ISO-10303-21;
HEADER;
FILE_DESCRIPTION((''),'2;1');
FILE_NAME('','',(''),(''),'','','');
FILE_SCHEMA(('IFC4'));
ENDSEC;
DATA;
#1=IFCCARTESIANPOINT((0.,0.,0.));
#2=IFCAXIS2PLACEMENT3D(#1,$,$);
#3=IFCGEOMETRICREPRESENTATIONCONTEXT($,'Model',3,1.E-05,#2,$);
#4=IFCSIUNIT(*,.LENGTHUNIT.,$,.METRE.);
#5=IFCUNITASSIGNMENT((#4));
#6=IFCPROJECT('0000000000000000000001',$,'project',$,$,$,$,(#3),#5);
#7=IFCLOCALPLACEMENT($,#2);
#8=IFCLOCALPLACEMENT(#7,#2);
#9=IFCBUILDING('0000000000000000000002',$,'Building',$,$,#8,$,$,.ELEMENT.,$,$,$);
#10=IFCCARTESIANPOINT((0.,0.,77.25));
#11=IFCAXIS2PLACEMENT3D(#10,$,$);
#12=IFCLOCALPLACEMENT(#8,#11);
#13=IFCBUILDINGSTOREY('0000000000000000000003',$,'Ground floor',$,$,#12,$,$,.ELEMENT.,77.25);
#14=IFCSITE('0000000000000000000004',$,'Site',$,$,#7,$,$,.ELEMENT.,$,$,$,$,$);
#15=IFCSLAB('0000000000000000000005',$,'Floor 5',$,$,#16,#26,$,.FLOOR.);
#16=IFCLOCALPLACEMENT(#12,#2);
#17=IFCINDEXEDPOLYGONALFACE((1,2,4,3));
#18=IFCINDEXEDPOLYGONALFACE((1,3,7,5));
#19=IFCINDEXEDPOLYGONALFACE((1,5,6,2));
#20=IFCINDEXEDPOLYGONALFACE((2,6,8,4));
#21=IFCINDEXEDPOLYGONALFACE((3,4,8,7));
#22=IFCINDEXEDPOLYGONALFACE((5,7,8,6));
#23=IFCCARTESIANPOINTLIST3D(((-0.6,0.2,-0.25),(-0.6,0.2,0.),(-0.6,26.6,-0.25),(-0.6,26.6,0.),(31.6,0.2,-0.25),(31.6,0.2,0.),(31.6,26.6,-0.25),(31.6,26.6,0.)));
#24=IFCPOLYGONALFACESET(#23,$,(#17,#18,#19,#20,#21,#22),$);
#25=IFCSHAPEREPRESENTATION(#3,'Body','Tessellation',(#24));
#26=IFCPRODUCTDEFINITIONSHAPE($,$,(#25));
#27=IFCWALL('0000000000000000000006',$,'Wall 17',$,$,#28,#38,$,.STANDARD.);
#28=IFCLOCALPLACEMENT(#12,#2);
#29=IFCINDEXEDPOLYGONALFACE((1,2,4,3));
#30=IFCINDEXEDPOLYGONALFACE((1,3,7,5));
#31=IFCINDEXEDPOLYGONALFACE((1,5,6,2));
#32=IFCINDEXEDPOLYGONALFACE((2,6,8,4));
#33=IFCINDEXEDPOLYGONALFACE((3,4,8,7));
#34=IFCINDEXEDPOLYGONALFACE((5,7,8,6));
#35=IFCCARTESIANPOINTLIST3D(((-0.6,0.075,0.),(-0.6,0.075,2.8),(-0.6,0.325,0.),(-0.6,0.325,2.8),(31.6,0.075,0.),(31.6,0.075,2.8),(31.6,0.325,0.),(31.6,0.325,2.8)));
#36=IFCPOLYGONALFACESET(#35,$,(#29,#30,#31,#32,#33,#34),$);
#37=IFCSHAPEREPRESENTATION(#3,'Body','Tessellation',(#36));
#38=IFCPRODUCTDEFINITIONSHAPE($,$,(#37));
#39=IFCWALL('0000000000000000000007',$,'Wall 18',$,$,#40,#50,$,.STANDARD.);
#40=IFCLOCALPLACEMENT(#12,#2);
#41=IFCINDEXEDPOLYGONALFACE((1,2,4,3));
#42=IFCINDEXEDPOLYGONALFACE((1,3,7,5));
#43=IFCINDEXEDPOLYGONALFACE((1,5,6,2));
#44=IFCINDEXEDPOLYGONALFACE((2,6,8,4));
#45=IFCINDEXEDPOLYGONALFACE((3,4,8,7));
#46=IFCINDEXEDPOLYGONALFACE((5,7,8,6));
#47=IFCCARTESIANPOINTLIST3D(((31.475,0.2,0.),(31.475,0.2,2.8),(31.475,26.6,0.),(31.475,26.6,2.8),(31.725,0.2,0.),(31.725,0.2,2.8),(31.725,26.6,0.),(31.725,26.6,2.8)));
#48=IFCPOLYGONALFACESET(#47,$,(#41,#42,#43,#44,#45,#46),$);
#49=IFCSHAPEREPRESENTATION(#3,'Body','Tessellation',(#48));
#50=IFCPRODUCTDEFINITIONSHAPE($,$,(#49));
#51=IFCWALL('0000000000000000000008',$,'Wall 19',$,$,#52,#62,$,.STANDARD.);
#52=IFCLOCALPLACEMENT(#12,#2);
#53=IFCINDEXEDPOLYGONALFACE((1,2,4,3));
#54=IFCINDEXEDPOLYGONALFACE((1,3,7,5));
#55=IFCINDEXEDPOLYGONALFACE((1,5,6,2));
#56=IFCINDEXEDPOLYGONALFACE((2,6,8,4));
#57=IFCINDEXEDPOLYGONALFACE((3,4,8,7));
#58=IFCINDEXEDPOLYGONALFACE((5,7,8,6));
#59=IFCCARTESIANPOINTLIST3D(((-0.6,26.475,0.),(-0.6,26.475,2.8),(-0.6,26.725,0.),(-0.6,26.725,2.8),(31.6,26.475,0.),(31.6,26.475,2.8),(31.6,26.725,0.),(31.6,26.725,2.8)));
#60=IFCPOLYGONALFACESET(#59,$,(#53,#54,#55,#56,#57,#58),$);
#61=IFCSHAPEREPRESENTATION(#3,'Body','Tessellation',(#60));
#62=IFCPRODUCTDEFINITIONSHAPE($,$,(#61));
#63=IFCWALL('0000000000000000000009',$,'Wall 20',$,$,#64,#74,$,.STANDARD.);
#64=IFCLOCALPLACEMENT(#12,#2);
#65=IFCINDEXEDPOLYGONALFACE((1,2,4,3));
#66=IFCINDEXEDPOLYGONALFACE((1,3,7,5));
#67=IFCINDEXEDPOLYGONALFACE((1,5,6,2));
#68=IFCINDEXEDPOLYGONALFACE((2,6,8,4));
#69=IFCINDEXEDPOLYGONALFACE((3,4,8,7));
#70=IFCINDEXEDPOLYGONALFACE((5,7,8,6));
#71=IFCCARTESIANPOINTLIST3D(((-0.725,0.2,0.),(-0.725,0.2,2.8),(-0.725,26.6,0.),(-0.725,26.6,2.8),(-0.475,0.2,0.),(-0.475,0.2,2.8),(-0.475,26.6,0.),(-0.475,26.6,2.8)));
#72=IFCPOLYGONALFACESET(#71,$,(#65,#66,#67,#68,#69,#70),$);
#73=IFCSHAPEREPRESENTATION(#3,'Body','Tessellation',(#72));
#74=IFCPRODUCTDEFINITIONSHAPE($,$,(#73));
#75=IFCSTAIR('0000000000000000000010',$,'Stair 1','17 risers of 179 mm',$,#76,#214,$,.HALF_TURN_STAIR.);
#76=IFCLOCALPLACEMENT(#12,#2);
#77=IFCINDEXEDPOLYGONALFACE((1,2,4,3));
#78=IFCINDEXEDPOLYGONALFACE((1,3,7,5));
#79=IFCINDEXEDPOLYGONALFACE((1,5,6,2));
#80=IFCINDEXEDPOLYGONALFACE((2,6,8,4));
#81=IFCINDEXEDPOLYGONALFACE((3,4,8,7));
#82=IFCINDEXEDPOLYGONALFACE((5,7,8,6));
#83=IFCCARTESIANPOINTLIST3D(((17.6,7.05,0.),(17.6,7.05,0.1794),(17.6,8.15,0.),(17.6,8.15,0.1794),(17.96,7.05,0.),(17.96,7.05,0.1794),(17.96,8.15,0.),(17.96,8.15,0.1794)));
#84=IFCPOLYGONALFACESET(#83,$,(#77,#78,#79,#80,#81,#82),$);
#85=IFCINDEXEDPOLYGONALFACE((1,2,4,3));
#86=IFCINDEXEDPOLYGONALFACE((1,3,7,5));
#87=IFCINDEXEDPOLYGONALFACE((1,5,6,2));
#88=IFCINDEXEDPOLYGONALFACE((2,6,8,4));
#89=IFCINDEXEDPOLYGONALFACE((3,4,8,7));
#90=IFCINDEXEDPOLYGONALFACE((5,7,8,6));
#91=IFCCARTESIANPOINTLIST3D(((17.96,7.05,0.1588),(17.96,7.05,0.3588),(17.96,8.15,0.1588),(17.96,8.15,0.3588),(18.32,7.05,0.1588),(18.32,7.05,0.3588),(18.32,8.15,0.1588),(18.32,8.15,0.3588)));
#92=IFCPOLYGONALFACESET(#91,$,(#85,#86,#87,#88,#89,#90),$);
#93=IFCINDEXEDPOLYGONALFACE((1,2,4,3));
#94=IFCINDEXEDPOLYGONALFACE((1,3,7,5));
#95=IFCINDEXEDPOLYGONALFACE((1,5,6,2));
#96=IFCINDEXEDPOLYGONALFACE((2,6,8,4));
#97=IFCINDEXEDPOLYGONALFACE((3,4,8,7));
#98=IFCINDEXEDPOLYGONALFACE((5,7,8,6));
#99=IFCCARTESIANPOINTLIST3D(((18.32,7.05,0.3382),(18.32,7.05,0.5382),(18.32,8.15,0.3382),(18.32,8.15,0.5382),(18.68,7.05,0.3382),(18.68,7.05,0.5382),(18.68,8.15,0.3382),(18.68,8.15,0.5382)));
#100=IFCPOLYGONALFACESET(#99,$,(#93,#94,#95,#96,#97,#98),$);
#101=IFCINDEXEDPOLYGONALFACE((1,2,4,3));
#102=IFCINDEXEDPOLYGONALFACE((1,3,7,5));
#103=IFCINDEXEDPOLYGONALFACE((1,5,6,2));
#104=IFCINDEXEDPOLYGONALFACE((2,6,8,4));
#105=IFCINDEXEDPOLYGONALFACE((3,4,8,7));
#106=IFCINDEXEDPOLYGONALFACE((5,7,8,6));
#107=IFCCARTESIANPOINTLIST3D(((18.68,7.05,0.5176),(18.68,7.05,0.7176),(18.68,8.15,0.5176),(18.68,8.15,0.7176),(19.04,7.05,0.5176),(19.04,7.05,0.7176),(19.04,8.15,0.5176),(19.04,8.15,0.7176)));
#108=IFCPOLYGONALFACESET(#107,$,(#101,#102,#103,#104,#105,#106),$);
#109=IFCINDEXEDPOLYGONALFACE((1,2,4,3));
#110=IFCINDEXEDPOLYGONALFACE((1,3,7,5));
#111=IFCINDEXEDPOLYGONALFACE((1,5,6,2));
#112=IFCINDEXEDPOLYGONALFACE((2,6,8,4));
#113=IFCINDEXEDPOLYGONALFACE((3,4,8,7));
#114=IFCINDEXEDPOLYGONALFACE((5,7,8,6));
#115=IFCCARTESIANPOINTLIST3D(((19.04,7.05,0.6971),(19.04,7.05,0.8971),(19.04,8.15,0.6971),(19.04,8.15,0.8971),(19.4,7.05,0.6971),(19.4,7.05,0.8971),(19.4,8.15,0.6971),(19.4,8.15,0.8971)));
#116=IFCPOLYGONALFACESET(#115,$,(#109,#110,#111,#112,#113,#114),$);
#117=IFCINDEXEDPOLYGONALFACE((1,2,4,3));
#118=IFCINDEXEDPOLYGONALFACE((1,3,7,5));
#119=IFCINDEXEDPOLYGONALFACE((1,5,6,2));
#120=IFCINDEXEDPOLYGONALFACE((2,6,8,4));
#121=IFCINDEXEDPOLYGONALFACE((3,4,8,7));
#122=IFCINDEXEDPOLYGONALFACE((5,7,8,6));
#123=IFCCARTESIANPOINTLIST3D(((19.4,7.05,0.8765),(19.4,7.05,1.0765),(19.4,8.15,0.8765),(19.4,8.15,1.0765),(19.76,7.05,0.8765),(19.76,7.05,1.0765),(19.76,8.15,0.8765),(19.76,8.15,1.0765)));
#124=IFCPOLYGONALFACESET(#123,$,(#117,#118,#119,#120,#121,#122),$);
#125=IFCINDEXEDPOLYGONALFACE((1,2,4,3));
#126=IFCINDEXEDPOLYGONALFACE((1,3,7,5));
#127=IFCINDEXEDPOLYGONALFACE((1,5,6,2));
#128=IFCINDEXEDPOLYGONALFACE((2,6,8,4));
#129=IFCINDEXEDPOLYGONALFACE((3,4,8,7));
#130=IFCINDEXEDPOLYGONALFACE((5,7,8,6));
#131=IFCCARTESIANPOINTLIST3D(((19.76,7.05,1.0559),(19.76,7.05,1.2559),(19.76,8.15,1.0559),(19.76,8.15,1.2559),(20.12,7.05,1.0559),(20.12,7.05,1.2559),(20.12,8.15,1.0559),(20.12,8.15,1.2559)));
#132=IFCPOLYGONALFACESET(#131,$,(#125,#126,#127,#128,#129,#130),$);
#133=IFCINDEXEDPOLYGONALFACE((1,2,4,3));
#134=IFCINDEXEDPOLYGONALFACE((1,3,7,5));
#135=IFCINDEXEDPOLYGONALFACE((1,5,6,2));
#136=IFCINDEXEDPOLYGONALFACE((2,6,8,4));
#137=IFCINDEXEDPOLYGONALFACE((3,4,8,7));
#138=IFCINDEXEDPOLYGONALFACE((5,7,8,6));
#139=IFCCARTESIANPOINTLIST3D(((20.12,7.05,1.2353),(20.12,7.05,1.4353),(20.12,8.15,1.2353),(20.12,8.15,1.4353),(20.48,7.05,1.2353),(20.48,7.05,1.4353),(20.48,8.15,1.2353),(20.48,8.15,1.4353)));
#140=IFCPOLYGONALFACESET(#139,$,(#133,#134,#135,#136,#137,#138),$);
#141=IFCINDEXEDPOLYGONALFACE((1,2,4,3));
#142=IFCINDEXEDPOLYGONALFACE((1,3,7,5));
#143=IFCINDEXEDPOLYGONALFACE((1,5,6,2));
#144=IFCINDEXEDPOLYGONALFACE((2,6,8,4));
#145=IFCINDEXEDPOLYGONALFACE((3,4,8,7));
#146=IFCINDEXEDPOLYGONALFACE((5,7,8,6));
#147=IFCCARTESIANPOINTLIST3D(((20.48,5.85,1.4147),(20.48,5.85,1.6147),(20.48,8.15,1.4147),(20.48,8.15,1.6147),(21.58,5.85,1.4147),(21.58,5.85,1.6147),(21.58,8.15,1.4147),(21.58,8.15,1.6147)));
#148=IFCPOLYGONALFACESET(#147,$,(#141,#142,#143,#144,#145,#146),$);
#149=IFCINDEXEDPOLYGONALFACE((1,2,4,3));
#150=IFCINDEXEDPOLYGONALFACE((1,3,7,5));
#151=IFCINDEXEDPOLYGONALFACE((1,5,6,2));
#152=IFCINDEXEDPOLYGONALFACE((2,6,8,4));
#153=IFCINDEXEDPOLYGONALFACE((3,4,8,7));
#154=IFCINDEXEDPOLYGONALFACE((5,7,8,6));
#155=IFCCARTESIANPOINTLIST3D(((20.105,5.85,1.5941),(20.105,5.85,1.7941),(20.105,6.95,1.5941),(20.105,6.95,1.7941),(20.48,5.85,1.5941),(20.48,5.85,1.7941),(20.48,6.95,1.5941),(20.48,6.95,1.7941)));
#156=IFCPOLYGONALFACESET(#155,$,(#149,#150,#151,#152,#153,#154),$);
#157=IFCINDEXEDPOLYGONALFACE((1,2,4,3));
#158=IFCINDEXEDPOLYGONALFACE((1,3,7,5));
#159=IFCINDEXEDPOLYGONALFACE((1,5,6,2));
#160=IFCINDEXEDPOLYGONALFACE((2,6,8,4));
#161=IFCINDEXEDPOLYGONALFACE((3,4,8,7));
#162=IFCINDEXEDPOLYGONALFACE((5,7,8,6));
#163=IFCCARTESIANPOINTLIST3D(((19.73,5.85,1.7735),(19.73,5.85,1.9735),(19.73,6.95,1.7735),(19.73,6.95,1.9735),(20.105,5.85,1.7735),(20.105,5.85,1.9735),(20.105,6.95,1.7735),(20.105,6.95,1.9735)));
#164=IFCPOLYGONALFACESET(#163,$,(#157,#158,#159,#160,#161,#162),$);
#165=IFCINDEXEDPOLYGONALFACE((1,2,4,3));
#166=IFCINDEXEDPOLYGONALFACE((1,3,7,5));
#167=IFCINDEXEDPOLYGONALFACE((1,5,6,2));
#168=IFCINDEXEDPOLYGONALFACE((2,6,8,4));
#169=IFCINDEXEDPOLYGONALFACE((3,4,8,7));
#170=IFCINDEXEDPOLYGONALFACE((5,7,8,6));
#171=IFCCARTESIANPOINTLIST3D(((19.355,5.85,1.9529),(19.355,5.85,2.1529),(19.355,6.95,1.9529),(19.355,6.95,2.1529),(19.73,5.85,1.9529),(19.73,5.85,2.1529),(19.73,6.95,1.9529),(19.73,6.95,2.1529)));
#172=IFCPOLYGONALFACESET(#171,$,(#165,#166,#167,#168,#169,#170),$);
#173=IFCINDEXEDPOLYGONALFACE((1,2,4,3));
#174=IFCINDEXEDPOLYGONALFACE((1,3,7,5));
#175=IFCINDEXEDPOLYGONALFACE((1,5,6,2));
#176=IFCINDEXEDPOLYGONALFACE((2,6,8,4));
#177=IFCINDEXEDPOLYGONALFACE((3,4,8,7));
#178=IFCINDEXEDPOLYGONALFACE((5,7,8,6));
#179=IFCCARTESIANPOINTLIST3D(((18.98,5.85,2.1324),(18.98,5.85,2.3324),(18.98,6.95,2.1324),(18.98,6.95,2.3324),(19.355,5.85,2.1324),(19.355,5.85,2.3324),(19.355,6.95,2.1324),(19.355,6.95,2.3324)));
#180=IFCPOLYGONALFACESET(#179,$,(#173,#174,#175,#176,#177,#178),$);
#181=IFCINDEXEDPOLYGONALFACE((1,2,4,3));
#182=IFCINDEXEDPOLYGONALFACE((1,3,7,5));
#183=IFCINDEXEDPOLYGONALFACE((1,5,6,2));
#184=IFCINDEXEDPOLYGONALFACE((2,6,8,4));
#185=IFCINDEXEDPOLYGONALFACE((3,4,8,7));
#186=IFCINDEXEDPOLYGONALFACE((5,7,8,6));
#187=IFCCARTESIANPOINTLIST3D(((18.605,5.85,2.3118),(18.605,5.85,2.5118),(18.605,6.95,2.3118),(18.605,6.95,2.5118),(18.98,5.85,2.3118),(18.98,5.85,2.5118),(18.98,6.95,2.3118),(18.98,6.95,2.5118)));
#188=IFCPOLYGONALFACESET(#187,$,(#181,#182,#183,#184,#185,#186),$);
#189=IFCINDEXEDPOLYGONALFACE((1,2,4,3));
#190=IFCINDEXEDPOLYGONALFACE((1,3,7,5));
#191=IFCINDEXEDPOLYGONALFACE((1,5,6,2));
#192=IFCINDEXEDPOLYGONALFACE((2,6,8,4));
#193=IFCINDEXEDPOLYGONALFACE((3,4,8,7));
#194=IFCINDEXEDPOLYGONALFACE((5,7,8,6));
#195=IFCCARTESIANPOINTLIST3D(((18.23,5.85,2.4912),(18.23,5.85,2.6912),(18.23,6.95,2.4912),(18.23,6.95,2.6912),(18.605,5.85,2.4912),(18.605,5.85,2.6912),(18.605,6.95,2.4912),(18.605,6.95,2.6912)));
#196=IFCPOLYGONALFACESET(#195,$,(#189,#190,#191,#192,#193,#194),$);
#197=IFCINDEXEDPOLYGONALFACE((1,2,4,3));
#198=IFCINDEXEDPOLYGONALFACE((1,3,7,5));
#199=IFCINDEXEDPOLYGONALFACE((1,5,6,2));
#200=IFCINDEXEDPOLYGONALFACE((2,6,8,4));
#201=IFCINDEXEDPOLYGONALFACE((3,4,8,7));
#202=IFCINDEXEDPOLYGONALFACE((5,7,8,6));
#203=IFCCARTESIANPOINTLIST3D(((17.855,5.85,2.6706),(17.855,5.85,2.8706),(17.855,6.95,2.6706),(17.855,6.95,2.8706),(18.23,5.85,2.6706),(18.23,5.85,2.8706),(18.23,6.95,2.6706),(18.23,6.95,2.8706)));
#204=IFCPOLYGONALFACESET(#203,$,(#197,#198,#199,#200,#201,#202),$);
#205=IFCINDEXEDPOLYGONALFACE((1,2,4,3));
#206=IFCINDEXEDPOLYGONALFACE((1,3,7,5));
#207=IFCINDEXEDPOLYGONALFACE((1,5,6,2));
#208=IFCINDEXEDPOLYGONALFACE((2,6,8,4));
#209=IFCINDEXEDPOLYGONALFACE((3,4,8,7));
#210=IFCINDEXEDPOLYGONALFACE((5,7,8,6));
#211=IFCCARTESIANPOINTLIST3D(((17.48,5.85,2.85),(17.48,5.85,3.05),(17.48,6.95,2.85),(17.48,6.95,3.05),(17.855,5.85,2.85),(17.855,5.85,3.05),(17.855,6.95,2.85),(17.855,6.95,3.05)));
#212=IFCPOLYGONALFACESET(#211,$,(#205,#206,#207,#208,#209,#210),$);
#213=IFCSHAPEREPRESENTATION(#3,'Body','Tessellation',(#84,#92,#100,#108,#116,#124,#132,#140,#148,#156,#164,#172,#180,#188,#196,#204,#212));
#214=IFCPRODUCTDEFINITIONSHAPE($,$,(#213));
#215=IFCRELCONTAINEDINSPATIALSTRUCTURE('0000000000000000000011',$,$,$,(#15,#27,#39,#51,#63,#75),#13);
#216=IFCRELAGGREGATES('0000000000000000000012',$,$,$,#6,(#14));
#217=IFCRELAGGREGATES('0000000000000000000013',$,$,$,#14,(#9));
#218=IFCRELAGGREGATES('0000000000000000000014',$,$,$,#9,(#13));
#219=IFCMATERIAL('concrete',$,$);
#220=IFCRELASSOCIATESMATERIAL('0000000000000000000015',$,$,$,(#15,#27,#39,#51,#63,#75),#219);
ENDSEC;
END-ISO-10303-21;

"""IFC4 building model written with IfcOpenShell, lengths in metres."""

from ifc_helpers import new_model, si_unit, frame, frame_2d, origin, place, context, project, spatial, polyline, rectangle, outline, extrude, material, element, save


model = new_model("IFC4")

# Units and contexts
model_context = context("Model", 3, precision=1e-05, world=origin())
ifc_project = project(units=[si_unit("LENGTHUNIT", "METRE")], contexts=[model_context])

# Site, building, storey
site_placement = place(None, origin())
site = spatial("IfcSite", under=ifc_project, at=site_placement, Name="Site", CompositionType="ELEMENT")
building_placement = place(site_placement, origin())
building = spatial("IfcBuilding", under=site, at=building_placement, Name="Building", CompositionType="ELEMENT")
storey_placement = place(building_placement, frame((0.0, 0.0, 77.25)))
storey = spatial("IfcBuildingStorey", under=building, at=storey_placement, Name="Ground floor", CompositionType="ELEMENT", Elevation=77.25)

# Slab
ifc_material = material(Name="concrete")
slab_placement = place(storey_placement, frame((0.0, 0.0, -0.25), z_axis=(0.0, 0.0, 1.0), x_axis=(1.0, 0.0, 0.0)))
element("IfcSlab", 1, at=slab_placement, inside=storey, material=ifc_material, Name="Floor 5", PredefinedType="FLOOR", context=model_context, shape_type="SweptSolid", body=[
    extrude(outline(polyline([(-0.6, 0.2), (31.6, 0.2), (31.6, 26.6), (-0.6, 26.6), (-0.6, 0.2)])), origin(), (0.0, 0.0, 1.0), 0.25),
])

# Walls
wall_1_placement = place(storey_placement, frame((-0.6, 0.2, 0.0), z_axis=(0.0, 0.0, 1.0), x_axis=(1.0, 0.0, 0.0)))
element("IfcWall", 2, at=wall_1_placement, inside=storey, material=ifc_material, Name="Wall 17", PredefinedType="STANDARD", context=model_context, shape_type="SweptSolid", body=[
    extrude(rectangle(XDim=32.2, YDim=0.25, at=frame_2d((16.1, 0.0))), origin(), (0.0, 0.0, 1.0), 2.8),
])
wall_2_placement = place(storey_placement, frame((31.6, 0.2, 0.0), z_axis=(0.0, 0.0, 1.0), x_axis=(0.0, 1.0, 0.0)))
element("IfcWall", 3, at=wall_2_placement, inside=storey, material=ifc_material, Name="Wall 18", PredefinedType="STANDARD", context=model_context, shape_type="SweptSolid", body=[
    extrude(rectangle(XDim=26.4, YDim=0.25, at=frame_2d((13.2, 0.0))), origin(), (0.0, 0.0, 1.0), 2.8),
])
wall_3_placement = place(storey_placement, frame((31.6, 26.6, 0.0), z_axis=(0.0, 0.0, 1.0), x_axis=(-1.0, 0.0, 0.0)))
element("IfcWall", 4, at=wall_3_placement, inside=storey, material=ifc_material, Name="Wall 19", PredefinedType="STANDARD", context=model_context, shape_type="SweptSolid", body=[
    extrude(rectangle(XDim=32.2, YDim=0.25, at=frame_2d((16.1, 0.0))), origin(), (0.0, 0.0, 1.0), 2.8),
])
wall_4_placement = place(storey_placement, frame((-0.6, 26.6, 0.0), z_axis=(0.0, 0.0, 1.0), x_axis=(0.0, -1.0, 0.0)))
element("IfcWall", 5, at=wall_4_placement, inside=storey, material=ifc_material, Name="Wall 20", PredefinedType="STANDARD", context=model_context, shape_type="SweptSolid", body=[
    extrude(rectangle(XDim=26.4, YDim=0.25, at=frame_2d((13.2, 0.0))), origin(), (0.0, 0.0, 1.0), 2.8),
])

# Stair
stair_1_placement = place(storey_placement, frame((17.6, 7.6, 0.0), z_axis=(0.0, 0.0, 1.0), x_axis=(1.0, 0.0, 0.0)))
element("IfcStair", 6, at=stair_1_placement, inside=storey, material=ifc_material, Name="Stair 1", Description="17 risers of 179 mm", PredefinedType="HALF_TURN_STAIR", context=model_context, shape_type="SweptSolid", body=[
    extrude(outline(polyline([(0.0, -0.55), (0.36, -0.55), (0.36, 0.55), (0.0, 0.55), (0.0, -0.55)])), origin(), (0.0, 0.0, 1.0), 0.1794),
    extrude(outline(polyline([(0.36, -0.55), (0.72, -0.55), (0.72, 0.55), (0.36, 0.55), (0.36, -0.55)])), frame((0.0, 0.0, 0.1588)), (0.0, 0.0, 1.0), 0.2),
    extrude(outline(polyline([(0.72, -0.55), (1.08, -0.55), (1.08, 0.55), (0.72, 0.55), (0.72, -0.55)])), frame((0.0, 0.0, 0.3382)), (0.0, 0.0, 1.0), 0.2),
    extrude(outline(polyline([(1.08, -0.55), (1.44, -0.55), (1.44, 0.55), (1.08, 0.55), (1.08, -0.55)])), frame((0.0, 0.0, 0.5176)), (0.0, 0.0, 1.0), 0.2),
    extrude(outline(polyline([(1.44, -0.55), (1.8, -0.55), (1.8, 0.55), (1.44, 0.55), (1.44, -0.55)])), frame((0.0, 0.0, 0.6971)), (0.0, 0.0, 1.0), 0.2),
    extrude(outline(polyline([(1.8, -0.55), (2.16, -0.55), (2.16, 0.55), (1.8, 0.55), (1.8, -0.55)])), frame((0.0, 0.0, 0.8765)), (0.0, 0.0, 1.0), 0.2),
    extrude(outline(polyline([(2.16, -0.55), (2.52, -0.55), (2.52, 0.55), (2.16, 0.55), (2.16, -0.55)])), frame((0.0, 0.0, 1.0559)), (0.0, 0.0, 1.0), 0.2),
    extrude(outline(polyline([(2.52, -0.55), (2.88, -0.55), (2.88, 0.55), (2.52, 0.55), (2.52, -0.55)])), frame((0.0, 0.0, 1.2353)), (0.0, 0.0, 1.0), 0.2),
    extrude(outline(polyline([(2.88, -1.75), (3.98, -1.75), (3.98, 0.55), (2.88, 0.55), (2.88, -1.75)])), frame((0.0, 0.0, 1.4147)), (0.0, 0.0, 1.0), 0.2),
    extrude(outline(polyline([(2.505, -1.75), (2.88, -1.75), (2.88, -0.65), (2.505, -0.65), (2.505, -1.75)])), frame((0.0, 0.0, 1.5941)), (0.0, 0.0, 1.0), 0.2),
    extrude(outline(polyline([(2.13, -1.75), (2.505, -1.75), (2.505, -0.65), (2.13, -0.65), (2.13, -1.75)])), frame((0.0, 0.0, 1.7735)), (0.0, 0.0, 1.0), 0.2),
    extrude(outline(polyline([(1.755, -1.75), (2.13, -1.75), (2.13, -0.65), (1.755, -0.65), (1.755, -1.75)])), frame((0.0, 0.0, 1.9529)), (0.0, 0.0, 1.0), 0.2),
    extrude(outline(polyline([(1.38, -1.75), (1.755, -1.75), (1.755, -0.65), (1.38, -0.65), (1.38, -1.75)])), frame((0.0, 0.0, 2.1324)), (0.0, 0.0, 1.0), 0.2),
    extrude(outline(polyline([(1.005, -1.75), (1.38, -1.75), (1.38, -0.65), (1.005, -0.65), (1.005, -1.75)])), frame((0.0, 0.0, 2.3118)), (0.0, 0.0, 1.0), 0.2),
    extrude(outline(polyline([(0.63, -1.75), (1.005, -1.75), (1.005, -0.65), (0.63, -0.65), (0.63, -1.75)])), frame((0.0, 0.0, 2.4912)), (0.0, 0.0, 1.0), 0.2),
    extrude(outline(polyline([(0.255, -1.75), (0.63, -1.75), (0.63, -0.65), (0.255, -0.65), (0.255, -1.75)])), frame((0.0, 0.0, 2.6706)), (0.0, 0.0, 1.0), 0.2),
    extrude(outline(polyline([(-0.12, -1.75), (0.255, -1.75), (0.255, -0.65), (-0.12, -0.65), (-0.12, -1.75)])), frame((0.0, 0.0, 2.85)), (0.0, 0.0, 1.0), 0.2),
])

save(model, "model.ifc")
